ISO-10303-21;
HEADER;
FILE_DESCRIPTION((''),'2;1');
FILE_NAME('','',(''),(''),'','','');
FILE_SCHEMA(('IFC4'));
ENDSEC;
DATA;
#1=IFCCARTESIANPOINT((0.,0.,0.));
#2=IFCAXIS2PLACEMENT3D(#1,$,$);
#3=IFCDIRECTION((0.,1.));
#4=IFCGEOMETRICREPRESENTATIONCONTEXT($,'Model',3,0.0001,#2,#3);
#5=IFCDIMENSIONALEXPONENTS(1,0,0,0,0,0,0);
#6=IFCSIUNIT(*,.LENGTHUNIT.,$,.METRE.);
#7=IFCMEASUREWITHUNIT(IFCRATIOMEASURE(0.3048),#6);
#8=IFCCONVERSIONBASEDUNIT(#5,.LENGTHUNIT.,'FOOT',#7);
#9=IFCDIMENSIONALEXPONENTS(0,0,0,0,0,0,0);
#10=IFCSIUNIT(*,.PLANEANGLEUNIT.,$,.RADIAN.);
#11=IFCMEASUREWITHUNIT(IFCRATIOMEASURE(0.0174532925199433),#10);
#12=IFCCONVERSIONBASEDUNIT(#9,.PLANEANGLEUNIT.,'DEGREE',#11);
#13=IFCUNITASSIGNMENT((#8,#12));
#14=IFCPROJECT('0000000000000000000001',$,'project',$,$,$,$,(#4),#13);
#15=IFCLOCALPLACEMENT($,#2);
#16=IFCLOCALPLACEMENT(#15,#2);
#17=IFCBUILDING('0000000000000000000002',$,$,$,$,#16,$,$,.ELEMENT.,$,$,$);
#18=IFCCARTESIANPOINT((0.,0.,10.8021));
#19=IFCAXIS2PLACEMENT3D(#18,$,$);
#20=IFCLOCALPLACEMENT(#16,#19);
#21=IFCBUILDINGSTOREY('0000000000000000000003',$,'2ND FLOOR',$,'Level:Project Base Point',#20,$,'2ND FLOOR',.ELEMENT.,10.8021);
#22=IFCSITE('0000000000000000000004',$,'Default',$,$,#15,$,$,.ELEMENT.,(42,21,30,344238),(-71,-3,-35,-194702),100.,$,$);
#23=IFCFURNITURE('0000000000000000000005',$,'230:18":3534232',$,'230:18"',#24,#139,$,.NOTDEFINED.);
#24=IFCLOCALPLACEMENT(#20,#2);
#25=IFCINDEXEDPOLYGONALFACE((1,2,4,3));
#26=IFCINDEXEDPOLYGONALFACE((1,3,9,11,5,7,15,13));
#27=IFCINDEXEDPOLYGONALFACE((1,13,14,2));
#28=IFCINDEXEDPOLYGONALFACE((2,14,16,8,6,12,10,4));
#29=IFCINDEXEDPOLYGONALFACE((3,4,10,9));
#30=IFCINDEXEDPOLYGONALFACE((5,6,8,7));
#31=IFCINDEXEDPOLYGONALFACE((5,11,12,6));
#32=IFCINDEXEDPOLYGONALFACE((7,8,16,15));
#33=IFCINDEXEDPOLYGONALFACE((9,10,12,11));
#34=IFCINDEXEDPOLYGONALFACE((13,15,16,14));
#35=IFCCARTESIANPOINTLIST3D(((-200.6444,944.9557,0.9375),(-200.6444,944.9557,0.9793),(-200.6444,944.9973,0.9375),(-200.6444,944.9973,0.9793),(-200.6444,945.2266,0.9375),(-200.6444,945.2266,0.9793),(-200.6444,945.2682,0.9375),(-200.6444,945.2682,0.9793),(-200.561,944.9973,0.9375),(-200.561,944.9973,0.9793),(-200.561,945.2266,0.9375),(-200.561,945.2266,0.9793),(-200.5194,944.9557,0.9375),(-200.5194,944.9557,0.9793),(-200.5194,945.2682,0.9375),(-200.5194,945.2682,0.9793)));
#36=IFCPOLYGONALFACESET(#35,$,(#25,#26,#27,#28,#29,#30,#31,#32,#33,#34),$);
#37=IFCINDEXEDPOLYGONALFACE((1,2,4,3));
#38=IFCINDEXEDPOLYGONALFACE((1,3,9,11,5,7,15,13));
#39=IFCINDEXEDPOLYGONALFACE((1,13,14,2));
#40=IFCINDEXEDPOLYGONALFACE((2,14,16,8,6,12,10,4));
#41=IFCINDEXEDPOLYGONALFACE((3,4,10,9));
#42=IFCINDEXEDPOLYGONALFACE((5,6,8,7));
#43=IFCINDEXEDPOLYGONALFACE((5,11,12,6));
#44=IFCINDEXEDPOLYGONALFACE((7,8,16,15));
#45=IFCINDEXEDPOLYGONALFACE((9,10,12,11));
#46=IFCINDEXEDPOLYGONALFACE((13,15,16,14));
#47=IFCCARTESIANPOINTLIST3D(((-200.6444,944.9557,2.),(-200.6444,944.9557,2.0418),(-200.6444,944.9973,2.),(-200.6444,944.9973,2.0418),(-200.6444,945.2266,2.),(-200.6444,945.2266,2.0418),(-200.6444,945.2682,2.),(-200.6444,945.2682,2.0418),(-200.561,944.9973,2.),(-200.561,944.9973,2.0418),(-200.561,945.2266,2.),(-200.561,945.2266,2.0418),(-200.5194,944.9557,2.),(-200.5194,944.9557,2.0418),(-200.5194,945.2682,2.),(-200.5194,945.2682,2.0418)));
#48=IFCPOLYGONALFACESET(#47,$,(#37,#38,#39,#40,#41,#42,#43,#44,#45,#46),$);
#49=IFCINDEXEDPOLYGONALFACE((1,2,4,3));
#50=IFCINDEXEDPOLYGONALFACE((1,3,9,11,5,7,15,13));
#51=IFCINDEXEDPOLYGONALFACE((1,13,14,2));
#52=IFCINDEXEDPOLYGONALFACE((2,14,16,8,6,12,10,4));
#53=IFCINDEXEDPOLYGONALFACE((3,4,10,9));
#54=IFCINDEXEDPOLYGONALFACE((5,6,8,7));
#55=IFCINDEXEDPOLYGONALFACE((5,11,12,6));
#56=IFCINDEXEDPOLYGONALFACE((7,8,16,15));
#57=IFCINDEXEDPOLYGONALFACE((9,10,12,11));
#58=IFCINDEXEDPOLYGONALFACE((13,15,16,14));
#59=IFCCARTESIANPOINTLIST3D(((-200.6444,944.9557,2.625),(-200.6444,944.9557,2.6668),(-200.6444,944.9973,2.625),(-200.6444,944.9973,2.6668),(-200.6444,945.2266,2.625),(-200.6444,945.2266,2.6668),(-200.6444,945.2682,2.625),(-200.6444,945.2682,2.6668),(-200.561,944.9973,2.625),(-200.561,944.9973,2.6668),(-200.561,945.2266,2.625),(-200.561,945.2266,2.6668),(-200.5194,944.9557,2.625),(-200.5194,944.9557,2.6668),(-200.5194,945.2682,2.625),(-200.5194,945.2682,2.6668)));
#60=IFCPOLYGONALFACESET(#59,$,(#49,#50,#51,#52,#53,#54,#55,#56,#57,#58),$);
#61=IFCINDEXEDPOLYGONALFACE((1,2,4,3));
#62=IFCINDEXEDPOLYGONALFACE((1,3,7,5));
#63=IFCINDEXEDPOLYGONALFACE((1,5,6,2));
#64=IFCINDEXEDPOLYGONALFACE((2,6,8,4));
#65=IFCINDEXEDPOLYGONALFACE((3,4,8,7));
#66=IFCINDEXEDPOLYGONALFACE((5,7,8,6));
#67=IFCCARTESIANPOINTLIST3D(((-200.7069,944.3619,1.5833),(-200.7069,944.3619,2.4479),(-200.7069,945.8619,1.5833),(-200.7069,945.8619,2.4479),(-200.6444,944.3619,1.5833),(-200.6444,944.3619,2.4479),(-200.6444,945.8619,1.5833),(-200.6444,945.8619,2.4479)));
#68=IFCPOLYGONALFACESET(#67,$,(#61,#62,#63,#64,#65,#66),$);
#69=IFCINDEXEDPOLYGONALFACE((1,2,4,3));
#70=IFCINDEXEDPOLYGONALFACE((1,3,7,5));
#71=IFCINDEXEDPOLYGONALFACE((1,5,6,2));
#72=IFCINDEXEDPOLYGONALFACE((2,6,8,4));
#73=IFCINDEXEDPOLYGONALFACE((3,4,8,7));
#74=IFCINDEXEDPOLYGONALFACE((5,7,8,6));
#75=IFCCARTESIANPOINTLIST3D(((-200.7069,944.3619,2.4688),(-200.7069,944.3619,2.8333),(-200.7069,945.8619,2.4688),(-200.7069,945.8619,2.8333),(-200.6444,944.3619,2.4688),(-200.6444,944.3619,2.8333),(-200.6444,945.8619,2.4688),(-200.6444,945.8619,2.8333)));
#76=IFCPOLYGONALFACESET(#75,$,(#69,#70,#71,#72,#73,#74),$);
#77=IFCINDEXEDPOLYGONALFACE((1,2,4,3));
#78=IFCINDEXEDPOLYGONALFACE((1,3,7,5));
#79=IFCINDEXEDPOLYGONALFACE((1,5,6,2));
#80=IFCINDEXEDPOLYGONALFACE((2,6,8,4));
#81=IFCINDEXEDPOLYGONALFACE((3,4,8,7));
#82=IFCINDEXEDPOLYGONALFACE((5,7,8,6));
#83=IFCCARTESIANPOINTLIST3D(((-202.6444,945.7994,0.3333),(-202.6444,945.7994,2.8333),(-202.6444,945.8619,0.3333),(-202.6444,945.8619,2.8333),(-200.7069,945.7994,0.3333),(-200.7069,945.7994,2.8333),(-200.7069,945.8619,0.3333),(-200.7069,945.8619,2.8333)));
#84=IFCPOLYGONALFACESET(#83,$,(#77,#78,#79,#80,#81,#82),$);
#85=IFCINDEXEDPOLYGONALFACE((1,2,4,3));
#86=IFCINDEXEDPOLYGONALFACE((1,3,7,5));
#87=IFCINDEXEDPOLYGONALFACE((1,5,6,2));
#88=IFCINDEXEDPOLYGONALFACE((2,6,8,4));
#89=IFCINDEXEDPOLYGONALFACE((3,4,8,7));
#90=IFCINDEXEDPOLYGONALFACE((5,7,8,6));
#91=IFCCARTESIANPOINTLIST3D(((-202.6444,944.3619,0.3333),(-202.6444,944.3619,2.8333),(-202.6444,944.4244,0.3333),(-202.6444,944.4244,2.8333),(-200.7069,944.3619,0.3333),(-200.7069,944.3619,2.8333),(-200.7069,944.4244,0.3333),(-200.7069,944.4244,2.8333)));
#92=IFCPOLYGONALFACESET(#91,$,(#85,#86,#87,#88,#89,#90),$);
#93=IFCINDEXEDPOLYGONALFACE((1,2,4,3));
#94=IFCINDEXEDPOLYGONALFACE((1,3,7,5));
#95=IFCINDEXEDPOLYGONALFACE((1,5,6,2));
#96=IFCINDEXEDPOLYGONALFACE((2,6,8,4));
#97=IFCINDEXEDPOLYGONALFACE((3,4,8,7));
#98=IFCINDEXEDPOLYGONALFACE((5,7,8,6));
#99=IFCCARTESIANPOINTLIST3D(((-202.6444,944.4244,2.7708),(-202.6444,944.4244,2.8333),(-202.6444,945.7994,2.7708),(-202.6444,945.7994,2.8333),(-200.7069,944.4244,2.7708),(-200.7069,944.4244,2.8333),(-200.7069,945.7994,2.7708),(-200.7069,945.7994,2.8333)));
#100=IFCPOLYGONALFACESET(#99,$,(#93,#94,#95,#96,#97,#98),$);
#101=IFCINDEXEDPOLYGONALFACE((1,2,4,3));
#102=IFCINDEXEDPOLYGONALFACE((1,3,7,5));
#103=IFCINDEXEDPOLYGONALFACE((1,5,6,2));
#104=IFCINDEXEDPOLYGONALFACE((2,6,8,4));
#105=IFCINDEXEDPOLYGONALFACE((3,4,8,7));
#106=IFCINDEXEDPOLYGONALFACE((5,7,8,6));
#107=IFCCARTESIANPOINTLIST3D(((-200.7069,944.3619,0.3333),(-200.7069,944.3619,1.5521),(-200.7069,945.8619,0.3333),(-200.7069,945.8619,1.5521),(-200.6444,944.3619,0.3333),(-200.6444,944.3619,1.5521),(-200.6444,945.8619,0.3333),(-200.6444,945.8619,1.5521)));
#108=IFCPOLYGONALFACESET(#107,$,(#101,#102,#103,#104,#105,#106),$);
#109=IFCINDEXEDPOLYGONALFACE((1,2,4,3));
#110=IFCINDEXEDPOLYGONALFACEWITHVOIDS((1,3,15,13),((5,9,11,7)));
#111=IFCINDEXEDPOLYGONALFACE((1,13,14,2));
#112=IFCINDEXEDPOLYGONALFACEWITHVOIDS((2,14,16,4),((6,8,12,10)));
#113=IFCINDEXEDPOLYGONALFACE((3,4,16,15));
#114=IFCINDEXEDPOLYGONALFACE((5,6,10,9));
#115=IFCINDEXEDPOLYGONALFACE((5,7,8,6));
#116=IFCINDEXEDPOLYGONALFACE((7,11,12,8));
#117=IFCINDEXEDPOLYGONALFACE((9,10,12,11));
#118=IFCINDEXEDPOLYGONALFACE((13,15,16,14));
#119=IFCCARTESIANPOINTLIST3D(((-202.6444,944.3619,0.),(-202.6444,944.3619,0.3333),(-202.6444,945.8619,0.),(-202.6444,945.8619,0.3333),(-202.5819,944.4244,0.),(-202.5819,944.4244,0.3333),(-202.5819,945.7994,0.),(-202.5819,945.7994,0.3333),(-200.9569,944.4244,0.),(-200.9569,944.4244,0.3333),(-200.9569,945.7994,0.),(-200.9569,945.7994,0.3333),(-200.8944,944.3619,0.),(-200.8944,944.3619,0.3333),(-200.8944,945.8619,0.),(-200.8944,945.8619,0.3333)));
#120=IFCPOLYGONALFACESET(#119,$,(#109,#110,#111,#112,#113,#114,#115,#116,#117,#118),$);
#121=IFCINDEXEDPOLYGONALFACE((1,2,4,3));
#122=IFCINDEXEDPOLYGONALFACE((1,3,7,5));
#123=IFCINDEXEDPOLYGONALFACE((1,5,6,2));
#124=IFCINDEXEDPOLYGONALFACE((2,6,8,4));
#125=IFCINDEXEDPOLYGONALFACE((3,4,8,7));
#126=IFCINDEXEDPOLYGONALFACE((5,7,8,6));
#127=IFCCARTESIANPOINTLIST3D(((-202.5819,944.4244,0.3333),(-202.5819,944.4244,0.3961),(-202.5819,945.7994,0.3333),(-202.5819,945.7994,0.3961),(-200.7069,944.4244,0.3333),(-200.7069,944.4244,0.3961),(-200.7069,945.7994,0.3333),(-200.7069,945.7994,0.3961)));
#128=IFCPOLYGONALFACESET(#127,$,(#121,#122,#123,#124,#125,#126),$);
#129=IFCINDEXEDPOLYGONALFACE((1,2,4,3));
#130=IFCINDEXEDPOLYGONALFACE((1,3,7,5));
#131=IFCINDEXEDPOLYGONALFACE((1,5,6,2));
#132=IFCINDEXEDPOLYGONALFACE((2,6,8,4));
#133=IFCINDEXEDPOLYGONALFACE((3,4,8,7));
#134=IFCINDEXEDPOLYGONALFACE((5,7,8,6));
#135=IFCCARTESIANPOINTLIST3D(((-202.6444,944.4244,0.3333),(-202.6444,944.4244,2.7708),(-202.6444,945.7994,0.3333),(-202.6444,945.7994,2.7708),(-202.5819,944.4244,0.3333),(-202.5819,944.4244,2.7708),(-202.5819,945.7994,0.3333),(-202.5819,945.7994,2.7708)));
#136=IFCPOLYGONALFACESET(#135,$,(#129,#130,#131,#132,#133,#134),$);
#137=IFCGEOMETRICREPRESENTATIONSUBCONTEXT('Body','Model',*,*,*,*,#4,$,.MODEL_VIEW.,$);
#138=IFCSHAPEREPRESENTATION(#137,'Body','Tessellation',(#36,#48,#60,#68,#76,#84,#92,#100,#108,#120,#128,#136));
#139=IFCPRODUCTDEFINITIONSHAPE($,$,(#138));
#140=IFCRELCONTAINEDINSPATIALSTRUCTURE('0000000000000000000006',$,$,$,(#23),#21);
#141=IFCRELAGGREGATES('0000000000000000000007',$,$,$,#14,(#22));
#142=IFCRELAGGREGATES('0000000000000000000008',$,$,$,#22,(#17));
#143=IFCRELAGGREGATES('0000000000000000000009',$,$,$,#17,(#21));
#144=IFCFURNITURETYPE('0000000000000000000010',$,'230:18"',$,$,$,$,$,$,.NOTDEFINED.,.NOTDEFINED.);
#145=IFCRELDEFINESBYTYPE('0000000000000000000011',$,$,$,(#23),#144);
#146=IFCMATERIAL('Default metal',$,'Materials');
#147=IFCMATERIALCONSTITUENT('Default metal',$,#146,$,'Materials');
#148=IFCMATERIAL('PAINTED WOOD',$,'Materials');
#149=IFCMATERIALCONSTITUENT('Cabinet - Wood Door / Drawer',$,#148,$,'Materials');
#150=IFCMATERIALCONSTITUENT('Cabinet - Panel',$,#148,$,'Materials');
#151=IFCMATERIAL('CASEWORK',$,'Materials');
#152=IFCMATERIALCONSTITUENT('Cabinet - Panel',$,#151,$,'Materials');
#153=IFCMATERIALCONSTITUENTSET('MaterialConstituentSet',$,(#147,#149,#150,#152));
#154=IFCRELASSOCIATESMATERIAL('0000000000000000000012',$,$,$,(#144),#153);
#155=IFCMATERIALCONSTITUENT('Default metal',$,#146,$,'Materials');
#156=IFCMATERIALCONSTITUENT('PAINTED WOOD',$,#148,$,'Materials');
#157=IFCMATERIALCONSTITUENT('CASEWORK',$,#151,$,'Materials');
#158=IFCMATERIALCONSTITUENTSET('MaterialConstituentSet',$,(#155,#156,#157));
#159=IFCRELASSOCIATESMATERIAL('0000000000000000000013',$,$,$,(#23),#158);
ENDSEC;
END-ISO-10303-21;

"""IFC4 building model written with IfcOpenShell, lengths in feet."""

from ifc_helpers import new_model, entity, si_unit, converted_unit, direction, frame, frame_2d, origin, origin_2d_with_axis, place, context, subcontext, project, spatial, polyline, rectangle, outline, extrude, source, transform, mapped, material, constituent, constituent_set, type_object, type_shapes, element, save


model = new_model("IFC4")

# Units and contexts
model_context = context("Model", 3, precision=0.0001, world=origin(), true_north=direction((0.0, 1.0)))
body_context = subcontext(model_context, "Body", "Model", "MODEL_VIEW")
ifc_project = project(units=[converted_unit("LENGTHUNIT", "FOOT", entity("IfcRatioMeasure", 0.3048), si_unit("LENGTHUNIT", "METRE"), dimensions=[1, 0, 0, 0, 0, 0, 0]), converted_unit("PLANEANGLEUNIT", "DEGREE", entity("IfcRatioMeasure", 0.0174532925199433), si_unit("PLANEANGLEUNIT", "RADIAN"), dimensions=[0, 0, 0, 0, 0, 0, 0])], contexts=[model_context])

# Site, building, storey
site_placement = place(None, origin())
site = spatial("IfcSite", under=ifc_project, at=site_placement, Name="Default", CompositionType="ELEMENT", RefLatitude=(42, 21, 30, 344238), RefLongitude=(-71, -3, -35, -194702), RefElevation=100.0)
building_placement = place(site_placement, origin())
building = spatial("IfcBuilding", under=site, at=building_placement, CompositionType="ELEMENT")
storey_placement = place(building_placement, frame((0.0, 0.0, 10.8021)))
storey = spatial("IfcBuildingStorey", under=building, at=storey_placement, Name="2ND FLOOR", ObjectType="Level:Project Base Point", LongName="2ND FLOOR", CompositionType="ELEMENT", Elevation=10.8021)

# Furniture
ifc_material_1 = material(Name="CASEWORK", Category="Materials")
ifc_material_2 = material(Name="PAINTED WOOD", Category="Materials")
ifc_material_3 = material(Name="Default metal", Category="Materials")
ifc_constituent_1 = constituent(ifc_material_3, Name="Default metal", Category="Materials")
ifc_constituent_2 = constituent(ifc_material_2, Name="PAINTED WOOD", Category="Materials")
ifc_constituent_3 = constituent(ifc_material_1, Name="CASEWORK", Category="Materials")
ifc_constituent_set_1 = constituent_set(constituents=[ifc_constituent_1, ifc_constituent_2, ifc_constituent_3], Name="MaterialConstituentSet")
ifc_constituent_4 = constituent(ifc_material_3, Name="Default metal", Category="Materials")
ifc_constituent_5 = constituent(ifc_material_2, Name="Cabinet - Wood Door / Drawer", Category="Materials")
ifc_constituent_6 = constituent(ifc_material_2, Name="Cabinet - Panel", Category="Materials")
ifc_constituent_7 = constituent(ifc_material_1, Name="Cabinet - Panel", Category="Materials")
ifc_constituent_set_2 = constituent_set(constituents=[ifc_constituent_4, ifc_constituent_5, ifc_constituent_6, ifc_constituent_7], Name="MaterialConstituentSet")
furniture_type_1 = type_object("IfcFurnitureType", Name="230:18\"", AssemblyPlace="NOTDEFINED", PredefinedType="NOTDEFINED", material=ifc_constituent_set_2)
shared_shape_1 = source(origin(), body_context, "Body", "SweptSolid", [
    extrude(outline(polyline([(-0.1562, -0.0521), (-0.1146, -0.0521), (-0.1146, 0.0313), (0.1146, 0.0313), (0.1146, -0.0521), (0.1562, -0.0521), (0.1562, 0.0729), (-0.1562, 0.0729), (-0.1562, -0.0521)])), frame((0.0615, 2.0521, 0.9375)), (0.0, 0.0, 1.0), 0.0418),
    extrude(outline(polyline([(-0.1562, -0.0521), (-0.1146, -0.0521), (-0.1146, 0.0313), (0.1146, 0.0313), (0.1146, -0.0521), (0.1562, -0.0521), (0.1562, 0.0729), (-0.1562, 0.0729), (-0.1562, -0.0521)])), frame((0.0615, 2.0521, 2.0)), (0.0, 0.0, 1.0), 0.0418),
    extrude(outline(polyline([(-0.1562, -0.0521), (-0.1146, -0.0521), (-0.1146, 0.0313), (0.1146, 0.0313), (0.1146, -0.0521), (0.1562, -0.0521), (0.1562, 0.0729), (-0.1562, 0.0729), (-0.1562, -0.0521)])), frame((0.0615, 2.0521, 2.625)), (0.0, 0.0, 1.0), 0.0418),
    extrude(rectangle(XDim=1.5, YDim=0.0625, at=frame_2d((0.0, 0.0), x_axis=(1.0, 0.0))), frame((0.0615, 1.9688, 1.5833), z_axis=(0.0, 0.0, 1.0), x_axis=(-1.0, 0.0, 0.0)), (0.0, 0.0, 1.0), 0.8646),
    extrude(rectangle(XDim=1.5, YDim=0.0625, at=frame_2d((0.0, 0.0), x_axis=(1.0, 0.0))), frame((0.0615, 1.9688, 2.4688), z_axis=(0.0, 0.0, 1.0), x_axis=(-1.0, 0.0, 0.0)), (0.0, 0.0, 1.0), 0.3646),
    extrude(rectangle(XDim=1.9375, YDim=0.0625, at=frame_2d((0.0, 0.0), x_axis=(1.0, 0.0))), frame((-0.6573, 0.9687, 0.3333), z_axis=(0.0, 0.0, 1.0), x_axis=(0.0, -1.0, 0.0)), (0.0, 0.0, 1.0), 2.5),
    extrude(rectangle(XDim=1.9375, YDim=0.0625, at=frame_2d((0.0, 0.0), x_axis=(1.0, 0.0))), frame((0.7802, 0.9687, 0.3333), z_axis=(0.0, 0.0, 1.0), x_axis=(0.0, -1.0, 0.0)), (0.0, 0.0, 1.0), 2.5),
    extrude(rectangle(XDim=1.9375, YDim=1.375, at=origin_2d_with_axis()), frame((0.0615, 0.9687, 2.7708), z_axis=(0.0, 0.0, 1.0), x_axis=(0.0, 1.0, 0.0)), (0.0, 0.0, 1.0), 0.0625),
    extrude(rectangle(XDim=1.5, YDim=0.0625, at=frame_2d((0.0, 0.0), x_axis=(1.0, 0.0))), frame((0.0615, 1.9688, 0.3333), z_axis=(0.0, 0.0, 1.0), x_axis=(-1.0, 0.0, 0.0)), (0.0, 0.0, 1.0), 1.2187),
    extrude(outline(polyline([(-0.875, -0.75), (0.875, -0.75), (0.875, 0.75), (-0.875, 0.75), (-0.875, -0.75)]), holes=[polyline([(-0.8125, -0.6875), (-0.8125, 0.6875), (0.8125, 0.6875), (0.8125, -0.6875), (-0.8125, -0.6875)])]), frame((0.0615, 0.875, 0.0), z_axis=(0.0, 0.0, 1.0), x_axis=(0.0, -1.0, 0.0)), (0.0, 0.0, 1.0), 0.3333),
    extrude(rectangle(XDim=1.875, YDim=1.375, at=origin_2d_with_axis()), frame((0.0615, 1.0, 0.3333), z_axis=(0.0, 0.0, 1.0), x_axis=(0.0, 1.0, 0.0)), (0.0, 0.0, 1.0), 0.0627),
    extrude(rectangle(XDim=1.375, YDim=0.0625, at=origin_2d_with_axis()), frame((0.0615, 0.0312, 0.3333), z_axis=(0.0, 0.0, 1.0), x_axis=(-1.0, 0.0, 0.0)), (0.0, 0.0, 1.0), 2.4375),
])
type_shapes(furniture_type_1, [shared_shape_1])
furniture_1_placement = place(storey_placement, frame((-202.6444, 945.1734, 0.0), z_axis=(0.0, 0.0, 1.0), x_axis=(0.0, -1.0, 0.0)))
element("IfcFurniture", 1, at=furniture_1_placement, inside=storey, type_object=furniture_type_1, material=ifc_constituent_set_1, Name="230:18\":3534232", ObjectType="230:18\"", PredefinedType="NOTDEFINED", context=body_context, shape_type="MappedRepresentation", body=[
    mapped(shared_shape_1, transform((0.0, 0.0, 0.0), scale=1.0)),
])

save(model, "model.ifc")
